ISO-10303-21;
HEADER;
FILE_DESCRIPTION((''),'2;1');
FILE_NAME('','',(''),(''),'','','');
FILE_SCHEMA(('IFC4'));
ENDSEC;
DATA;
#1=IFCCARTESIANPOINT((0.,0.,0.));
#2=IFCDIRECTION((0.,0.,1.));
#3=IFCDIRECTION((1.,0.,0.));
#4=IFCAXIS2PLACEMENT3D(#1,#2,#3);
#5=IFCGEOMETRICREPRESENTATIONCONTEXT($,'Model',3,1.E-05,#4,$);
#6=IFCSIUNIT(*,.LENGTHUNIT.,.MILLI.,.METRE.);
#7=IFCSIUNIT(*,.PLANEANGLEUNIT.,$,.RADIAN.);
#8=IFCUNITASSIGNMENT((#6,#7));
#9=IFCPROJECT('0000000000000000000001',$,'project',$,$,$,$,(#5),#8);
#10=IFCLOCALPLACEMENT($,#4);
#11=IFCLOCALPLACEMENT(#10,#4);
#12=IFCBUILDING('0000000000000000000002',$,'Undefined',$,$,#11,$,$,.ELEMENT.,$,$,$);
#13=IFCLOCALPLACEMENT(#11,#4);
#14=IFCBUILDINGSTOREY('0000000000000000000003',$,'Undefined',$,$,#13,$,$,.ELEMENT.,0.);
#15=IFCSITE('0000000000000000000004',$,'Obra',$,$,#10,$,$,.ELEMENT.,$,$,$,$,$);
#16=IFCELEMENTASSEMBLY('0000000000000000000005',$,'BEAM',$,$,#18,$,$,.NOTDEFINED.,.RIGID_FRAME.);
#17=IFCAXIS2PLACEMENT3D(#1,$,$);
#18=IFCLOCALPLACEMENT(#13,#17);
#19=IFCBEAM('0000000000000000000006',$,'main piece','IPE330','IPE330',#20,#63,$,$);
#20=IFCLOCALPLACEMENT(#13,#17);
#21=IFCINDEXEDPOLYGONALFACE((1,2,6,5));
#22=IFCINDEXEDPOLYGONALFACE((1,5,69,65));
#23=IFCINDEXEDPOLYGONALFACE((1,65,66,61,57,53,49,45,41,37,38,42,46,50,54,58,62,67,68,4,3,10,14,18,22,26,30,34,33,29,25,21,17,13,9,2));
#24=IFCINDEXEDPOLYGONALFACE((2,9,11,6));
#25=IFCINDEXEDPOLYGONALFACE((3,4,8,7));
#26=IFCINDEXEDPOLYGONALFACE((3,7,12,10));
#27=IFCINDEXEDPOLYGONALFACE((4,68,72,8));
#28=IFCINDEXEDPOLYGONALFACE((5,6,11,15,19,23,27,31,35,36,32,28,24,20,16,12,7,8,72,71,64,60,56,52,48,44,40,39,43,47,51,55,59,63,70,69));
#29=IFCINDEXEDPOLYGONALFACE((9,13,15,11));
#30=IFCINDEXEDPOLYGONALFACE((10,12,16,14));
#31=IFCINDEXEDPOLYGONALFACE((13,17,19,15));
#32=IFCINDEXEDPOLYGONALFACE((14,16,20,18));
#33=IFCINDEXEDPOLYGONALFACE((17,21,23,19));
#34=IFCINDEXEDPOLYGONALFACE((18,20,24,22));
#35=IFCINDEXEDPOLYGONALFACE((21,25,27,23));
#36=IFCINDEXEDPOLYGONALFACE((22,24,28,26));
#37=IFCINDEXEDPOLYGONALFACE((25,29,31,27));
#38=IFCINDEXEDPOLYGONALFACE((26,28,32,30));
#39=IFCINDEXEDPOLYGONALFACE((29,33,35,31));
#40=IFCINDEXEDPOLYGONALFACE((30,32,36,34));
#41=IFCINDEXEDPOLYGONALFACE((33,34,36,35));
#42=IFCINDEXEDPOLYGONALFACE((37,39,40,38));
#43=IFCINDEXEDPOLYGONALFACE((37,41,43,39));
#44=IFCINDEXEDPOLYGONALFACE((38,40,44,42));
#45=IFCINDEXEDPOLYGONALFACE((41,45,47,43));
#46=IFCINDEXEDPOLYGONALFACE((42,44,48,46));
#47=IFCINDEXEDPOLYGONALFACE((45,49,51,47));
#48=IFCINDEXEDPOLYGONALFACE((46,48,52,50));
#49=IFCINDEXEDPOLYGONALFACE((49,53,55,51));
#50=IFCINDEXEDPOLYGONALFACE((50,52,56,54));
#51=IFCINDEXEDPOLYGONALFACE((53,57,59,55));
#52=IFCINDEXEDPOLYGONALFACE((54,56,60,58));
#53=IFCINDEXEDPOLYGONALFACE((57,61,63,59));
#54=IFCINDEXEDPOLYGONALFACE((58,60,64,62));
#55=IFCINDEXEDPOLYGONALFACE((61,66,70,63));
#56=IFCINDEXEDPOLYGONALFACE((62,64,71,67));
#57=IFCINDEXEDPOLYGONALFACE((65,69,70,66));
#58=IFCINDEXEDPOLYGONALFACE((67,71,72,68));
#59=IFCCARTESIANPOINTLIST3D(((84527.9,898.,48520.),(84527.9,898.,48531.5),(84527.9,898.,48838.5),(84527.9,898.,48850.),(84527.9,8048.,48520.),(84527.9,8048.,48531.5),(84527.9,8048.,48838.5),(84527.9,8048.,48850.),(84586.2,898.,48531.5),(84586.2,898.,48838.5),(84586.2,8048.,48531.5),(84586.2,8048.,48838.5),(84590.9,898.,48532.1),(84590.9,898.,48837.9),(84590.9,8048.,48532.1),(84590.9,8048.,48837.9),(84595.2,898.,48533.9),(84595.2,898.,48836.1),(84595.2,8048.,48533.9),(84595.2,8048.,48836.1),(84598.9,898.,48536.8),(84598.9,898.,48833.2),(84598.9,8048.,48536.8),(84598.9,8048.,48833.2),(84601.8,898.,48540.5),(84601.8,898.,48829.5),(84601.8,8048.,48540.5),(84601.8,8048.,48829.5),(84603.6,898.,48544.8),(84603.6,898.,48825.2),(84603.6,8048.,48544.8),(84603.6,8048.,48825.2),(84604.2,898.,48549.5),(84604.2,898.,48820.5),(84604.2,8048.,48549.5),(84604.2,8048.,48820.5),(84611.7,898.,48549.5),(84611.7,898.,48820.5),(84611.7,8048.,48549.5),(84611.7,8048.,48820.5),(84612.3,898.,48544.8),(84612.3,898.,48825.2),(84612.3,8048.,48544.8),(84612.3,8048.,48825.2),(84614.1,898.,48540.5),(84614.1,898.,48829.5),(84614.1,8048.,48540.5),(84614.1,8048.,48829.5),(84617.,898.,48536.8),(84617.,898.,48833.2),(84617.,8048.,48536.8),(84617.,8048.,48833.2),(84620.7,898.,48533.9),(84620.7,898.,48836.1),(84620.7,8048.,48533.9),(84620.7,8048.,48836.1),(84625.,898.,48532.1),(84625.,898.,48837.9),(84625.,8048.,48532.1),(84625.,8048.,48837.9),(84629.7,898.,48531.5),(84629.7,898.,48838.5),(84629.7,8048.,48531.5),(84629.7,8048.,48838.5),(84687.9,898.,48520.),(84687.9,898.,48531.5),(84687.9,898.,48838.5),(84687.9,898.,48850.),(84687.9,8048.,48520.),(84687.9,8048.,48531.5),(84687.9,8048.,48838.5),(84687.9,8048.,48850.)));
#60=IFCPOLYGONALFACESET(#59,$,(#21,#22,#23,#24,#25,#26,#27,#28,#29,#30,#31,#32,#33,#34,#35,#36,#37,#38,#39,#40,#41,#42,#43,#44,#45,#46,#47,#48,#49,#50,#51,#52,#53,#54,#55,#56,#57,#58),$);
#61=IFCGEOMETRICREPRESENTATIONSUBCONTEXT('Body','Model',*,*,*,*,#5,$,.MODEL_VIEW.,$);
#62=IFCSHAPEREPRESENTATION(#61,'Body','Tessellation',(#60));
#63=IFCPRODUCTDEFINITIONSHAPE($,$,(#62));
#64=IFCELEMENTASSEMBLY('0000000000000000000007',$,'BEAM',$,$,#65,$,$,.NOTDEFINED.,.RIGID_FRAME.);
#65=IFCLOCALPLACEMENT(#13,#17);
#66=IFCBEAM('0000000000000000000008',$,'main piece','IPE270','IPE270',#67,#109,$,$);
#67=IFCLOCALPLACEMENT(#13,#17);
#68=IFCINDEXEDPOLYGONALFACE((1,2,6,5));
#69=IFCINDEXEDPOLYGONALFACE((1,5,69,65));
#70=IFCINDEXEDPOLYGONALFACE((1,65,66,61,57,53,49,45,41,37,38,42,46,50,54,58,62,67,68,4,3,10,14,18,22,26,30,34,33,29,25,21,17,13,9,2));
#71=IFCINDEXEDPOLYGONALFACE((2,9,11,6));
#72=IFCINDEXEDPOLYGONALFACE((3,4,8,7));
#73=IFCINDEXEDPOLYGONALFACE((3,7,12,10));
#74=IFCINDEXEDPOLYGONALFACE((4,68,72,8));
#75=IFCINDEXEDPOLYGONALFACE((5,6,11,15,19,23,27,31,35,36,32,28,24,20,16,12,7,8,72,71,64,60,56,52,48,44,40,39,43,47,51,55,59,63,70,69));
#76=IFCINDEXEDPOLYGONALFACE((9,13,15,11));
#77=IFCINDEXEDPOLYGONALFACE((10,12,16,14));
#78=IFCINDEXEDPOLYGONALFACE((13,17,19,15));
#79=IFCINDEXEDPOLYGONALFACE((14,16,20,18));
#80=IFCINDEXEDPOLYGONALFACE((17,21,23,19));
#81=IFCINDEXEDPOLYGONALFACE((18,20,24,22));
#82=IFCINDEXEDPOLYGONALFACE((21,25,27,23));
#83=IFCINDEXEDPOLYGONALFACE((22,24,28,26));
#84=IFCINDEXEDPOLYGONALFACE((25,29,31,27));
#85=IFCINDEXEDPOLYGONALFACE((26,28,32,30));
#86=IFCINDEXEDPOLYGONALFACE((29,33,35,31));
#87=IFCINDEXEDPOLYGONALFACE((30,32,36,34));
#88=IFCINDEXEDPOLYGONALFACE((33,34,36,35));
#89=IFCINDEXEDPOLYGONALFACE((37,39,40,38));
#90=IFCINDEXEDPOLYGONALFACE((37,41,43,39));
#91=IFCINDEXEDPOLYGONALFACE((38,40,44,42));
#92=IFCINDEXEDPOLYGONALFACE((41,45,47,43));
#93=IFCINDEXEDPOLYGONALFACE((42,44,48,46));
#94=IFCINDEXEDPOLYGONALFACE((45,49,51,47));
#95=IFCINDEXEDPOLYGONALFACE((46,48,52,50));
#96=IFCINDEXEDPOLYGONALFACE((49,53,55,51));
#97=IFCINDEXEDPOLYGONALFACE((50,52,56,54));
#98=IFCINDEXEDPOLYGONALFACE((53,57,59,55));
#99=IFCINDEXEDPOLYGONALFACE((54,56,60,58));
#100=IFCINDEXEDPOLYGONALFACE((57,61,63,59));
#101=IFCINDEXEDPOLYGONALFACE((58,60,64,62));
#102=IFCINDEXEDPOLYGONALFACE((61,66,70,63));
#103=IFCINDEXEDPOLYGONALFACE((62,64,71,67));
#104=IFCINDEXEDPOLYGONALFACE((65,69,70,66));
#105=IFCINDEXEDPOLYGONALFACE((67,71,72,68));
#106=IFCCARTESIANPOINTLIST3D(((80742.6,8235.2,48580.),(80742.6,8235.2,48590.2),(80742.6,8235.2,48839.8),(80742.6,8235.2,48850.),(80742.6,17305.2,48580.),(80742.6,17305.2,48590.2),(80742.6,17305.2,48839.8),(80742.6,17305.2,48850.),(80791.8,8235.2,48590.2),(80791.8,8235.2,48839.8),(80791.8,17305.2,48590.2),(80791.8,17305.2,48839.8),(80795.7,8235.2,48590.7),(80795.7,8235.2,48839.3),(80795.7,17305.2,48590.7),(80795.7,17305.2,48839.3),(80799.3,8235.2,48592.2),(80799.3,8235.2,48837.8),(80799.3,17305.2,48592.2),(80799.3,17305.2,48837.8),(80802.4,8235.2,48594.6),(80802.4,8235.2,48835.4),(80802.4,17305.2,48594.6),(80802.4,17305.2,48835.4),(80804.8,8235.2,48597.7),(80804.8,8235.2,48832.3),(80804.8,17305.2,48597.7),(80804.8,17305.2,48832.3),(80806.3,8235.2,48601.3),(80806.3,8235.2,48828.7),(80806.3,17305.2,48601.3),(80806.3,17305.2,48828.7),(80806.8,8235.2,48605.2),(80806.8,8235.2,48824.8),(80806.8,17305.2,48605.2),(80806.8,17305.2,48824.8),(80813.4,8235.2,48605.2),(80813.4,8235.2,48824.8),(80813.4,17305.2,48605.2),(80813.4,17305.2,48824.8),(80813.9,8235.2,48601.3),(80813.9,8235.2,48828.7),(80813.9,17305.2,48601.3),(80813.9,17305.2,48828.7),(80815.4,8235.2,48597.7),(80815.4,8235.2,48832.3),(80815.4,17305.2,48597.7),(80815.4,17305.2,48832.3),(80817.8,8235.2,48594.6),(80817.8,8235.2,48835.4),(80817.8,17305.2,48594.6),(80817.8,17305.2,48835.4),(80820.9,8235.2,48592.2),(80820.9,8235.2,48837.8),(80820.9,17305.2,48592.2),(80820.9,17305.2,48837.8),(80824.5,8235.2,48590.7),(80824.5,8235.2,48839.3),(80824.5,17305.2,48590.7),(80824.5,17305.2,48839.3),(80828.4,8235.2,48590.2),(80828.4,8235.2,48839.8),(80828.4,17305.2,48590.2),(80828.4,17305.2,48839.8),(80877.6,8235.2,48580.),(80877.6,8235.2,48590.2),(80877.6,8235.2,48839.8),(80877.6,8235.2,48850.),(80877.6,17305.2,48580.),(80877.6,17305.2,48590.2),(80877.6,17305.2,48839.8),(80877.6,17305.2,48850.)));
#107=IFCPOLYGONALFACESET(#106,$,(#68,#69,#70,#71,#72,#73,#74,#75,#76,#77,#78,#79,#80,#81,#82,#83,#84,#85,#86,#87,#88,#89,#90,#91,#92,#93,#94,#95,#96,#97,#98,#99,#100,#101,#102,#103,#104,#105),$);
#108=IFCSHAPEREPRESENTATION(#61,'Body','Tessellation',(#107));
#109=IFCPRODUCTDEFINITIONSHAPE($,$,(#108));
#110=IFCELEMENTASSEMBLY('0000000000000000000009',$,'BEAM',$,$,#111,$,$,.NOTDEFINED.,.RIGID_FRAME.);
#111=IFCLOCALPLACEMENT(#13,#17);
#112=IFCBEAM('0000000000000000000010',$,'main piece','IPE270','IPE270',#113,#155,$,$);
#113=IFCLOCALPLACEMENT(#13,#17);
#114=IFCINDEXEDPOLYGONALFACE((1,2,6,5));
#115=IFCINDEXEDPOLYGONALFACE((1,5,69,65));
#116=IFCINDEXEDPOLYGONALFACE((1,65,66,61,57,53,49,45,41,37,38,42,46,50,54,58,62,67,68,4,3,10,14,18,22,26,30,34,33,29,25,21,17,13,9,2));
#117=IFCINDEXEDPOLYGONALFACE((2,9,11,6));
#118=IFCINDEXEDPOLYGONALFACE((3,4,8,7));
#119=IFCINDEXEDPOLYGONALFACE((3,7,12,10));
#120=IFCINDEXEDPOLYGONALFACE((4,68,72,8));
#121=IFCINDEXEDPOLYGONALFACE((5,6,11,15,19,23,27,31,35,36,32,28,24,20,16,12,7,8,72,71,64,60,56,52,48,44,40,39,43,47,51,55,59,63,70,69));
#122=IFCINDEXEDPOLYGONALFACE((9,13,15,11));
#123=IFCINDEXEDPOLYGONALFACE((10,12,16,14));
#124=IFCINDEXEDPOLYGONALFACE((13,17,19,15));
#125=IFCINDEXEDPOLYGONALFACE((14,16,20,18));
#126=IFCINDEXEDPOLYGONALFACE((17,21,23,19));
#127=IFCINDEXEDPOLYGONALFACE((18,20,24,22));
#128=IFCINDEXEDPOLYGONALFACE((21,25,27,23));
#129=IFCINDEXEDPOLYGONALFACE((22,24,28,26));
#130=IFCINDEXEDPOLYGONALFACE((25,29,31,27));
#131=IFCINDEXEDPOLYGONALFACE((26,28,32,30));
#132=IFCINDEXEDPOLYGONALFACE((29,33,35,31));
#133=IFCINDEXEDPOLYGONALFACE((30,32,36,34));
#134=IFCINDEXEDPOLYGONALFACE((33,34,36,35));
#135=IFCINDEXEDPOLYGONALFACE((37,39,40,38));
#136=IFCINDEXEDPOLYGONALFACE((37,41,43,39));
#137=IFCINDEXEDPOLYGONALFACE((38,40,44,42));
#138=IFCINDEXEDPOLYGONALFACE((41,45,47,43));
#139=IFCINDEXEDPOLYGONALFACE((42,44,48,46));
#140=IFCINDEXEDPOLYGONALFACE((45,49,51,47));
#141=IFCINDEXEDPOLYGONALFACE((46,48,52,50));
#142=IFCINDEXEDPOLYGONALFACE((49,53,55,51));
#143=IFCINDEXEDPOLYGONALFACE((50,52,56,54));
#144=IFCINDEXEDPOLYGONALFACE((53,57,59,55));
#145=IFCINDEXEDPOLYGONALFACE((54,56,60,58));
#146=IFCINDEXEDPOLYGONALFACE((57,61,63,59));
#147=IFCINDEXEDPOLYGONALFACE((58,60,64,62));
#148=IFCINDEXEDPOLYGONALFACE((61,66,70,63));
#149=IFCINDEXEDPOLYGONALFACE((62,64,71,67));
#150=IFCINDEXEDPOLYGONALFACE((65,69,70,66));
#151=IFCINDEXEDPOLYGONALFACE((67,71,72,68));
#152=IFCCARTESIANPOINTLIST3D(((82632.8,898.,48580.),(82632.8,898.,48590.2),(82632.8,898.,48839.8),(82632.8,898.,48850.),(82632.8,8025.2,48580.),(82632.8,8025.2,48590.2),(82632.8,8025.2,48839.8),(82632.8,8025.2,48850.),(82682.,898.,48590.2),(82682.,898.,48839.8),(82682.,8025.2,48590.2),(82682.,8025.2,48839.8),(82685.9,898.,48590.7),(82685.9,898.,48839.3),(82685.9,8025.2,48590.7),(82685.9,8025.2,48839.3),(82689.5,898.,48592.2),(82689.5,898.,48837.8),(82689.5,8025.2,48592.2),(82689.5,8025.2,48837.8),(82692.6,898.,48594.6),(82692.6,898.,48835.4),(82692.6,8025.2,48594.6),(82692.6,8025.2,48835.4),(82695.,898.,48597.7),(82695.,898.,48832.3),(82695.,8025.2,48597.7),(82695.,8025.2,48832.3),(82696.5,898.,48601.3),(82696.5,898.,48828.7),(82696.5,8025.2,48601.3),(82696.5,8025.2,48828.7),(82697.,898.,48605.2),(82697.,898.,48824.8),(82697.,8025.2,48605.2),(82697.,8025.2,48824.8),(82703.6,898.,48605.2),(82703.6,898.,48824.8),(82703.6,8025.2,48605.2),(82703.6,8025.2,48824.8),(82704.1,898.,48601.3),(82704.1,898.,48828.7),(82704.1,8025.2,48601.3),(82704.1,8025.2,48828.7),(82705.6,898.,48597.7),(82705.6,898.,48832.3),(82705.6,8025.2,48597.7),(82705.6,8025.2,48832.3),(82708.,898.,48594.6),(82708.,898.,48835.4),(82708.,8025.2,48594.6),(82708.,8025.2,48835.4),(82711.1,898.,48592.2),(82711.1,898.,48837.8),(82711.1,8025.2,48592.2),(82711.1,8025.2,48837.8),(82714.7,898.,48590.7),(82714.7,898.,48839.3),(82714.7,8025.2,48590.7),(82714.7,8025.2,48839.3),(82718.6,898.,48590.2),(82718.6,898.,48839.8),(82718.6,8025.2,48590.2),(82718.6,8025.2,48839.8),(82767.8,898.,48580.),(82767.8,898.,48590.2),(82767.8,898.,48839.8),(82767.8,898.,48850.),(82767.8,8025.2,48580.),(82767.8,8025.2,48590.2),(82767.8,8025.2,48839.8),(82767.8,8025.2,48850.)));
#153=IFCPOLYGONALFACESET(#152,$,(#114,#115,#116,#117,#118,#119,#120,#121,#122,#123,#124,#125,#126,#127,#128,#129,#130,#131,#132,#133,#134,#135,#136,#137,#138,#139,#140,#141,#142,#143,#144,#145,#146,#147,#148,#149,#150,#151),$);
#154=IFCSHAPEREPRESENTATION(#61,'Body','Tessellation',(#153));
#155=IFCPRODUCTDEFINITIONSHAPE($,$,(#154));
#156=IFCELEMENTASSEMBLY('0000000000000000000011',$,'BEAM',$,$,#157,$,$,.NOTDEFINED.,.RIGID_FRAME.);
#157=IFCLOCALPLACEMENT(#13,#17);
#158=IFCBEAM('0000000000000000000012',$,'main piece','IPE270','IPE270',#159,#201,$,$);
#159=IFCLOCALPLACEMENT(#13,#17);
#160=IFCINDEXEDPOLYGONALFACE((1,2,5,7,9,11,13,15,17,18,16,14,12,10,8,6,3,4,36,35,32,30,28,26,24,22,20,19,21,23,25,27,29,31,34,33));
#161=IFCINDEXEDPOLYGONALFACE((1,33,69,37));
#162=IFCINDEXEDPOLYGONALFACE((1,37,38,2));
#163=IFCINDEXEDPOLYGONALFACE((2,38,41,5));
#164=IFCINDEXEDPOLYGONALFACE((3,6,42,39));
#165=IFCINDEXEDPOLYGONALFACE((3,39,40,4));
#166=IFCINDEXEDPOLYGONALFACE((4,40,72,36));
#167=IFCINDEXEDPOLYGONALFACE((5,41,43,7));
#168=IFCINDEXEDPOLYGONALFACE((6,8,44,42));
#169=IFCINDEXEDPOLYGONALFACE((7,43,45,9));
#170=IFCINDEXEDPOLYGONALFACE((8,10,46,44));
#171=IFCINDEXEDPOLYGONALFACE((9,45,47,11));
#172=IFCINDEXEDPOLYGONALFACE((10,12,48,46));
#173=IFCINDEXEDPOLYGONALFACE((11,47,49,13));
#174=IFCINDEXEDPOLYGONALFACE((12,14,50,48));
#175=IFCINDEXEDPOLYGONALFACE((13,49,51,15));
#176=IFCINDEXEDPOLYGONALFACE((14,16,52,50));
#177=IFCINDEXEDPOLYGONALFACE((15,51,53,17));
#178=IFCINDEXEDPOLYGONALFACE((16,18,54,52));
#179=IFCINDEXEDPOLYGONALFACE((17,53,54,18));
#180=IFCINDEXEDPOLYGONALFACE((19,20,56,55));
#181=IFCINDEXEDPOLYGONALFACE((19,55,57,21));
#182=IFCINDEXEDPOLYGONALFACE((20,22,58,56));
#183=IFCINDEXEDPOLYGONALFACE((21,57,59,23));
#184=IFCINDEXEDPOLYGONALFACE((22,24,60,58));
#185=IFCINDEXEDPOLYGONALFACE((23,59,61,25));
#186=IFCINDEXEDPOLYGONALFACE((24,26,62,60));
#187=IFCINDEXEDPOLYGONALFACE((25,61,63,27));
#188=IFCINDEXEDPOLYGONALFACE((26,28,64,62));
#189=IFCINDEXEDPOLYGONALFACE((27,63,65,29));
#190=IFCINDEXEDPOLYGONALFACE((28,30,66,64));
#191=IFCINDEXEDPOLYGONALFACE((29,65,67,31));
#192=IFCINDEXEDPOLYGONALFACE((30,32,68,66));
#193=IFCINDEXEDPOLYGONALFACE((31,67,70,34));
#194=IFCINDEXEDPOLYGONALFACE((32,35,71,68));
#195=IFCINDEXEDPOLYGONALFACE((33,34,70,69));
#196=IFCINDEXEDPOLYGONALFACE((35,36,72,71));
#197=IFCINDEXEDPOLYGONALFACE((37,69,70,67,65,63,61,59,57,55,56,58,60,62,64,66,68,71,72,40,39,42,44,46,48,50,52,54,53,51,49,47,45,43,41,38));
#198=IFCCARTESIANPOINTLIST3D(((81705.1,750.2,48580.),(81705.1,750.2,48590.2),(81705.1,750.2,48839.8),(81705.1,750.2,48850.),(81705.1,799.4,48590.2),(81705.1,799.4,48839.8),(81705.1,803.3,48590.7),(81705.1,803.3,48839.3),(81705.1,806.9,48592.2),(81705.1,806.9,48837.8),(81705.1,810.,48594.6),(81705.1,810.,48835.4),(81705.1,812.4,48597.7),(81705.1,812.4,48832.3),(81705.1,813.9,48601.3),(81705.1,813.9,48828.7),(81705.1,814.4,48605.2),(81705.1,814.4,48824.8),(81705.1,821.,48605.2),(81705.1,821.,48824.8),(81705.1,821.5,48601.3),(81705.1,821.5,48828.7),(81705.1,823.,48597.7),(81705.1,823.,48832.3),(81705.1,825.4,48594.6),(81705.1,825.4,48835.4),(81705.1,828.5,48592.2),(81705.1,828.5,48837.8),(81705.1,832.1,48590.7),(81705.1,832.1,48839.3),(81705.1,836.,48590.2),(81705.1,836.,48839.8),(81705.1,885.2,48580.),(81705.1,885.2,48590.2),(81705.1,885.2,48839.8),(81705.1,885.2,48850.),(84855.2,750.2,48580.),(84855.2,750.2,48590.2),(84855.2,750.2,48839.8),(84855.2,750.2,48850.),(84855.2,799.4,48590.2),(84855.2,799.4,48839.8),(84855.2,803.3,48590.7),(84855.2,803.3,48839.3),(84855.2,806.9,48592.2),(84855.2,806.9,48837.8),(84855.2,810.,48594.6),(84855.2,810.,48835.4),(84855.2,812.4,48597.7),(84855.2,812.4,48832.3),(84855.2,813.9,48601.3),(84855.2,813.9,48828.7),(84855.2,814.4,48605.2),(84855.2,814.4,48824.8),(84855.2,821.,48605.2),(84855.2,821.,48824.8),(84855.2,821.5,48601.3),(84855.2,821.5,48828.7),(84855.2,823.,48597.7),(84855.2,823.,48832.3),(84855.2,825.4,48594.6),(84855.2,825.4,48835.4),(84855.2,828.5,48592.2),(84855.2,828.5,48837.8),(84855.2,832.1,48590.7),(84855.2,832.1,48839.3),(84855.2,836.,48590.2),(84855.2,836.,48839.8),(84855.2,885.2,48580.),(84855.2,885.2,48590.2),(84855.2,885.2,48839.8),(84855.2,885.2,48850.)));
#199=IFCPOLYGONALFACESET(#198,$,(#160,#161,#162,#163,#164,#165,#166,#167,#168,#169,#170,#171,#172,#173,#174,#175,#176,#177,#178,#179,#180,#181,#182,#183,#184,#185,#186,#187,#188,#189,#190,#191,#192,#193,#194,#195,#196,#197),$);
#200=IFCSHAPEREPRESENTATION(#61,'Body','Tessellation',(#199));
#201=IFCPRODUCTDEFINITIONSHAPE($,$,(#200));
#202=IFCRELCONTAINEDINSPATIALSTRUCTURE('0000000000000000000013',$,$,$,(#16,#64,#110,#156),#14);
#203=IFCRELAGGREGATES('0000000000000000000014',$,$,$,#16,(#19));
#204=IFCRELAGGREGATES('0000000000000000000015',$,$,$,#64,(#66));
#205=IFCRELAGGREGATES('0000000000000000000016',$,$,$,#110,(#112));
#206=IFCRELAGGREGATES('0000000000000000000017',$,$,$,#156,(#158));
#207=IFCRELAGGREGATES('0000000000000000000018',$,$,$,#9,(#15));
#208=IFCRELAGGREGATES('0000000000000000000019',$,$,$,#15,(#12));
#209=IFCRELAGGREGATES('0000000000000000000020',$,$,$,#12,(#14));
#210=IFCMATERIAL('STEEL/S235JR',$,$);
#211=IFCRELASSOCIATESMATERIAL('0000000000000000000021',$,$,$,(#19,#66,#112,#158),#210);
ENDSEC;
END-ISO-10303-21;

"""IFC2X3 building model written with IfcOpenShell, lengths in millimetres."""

from ifc_helpers import new_model, si_unit, frame, origin_with_axes, origin_2d_with_axis, place, context, subcontext, project, spatial, i_section, extrude, material, element, aggregate, save


model = new_model("IFC2X3")

# Units and contexts
model_context = context("Model", 3, precision=1e-05, world=origin_with_axes())
body_context = subcontext(model_context, "Body", "Model", "MODEL_VIEW")
ifc_project = project(units=[si_unit("LENGTHUNIT", "METRE", prefix="MILLI"), si_unit("PLANEANGLEUNIT", "RADIAN")], contexts=[model_context])

# Site, building, storey
site_placement = place(None, origin_with_axes())
site = spatial("IfcSite", under=ifc_project, at=site_placement, Name="Obra", CompositionType="ELEMENT")
building_placement = place(site_placement, origin_with_axes())
building = spatial("IfcBuilding", under=site, at=building_placement, Name="Undefined", CompositionType="ELEMENT")
storey_placement = place(building_placement, origin_with_axes())
storey = spatial("IfcBuildingStorey", under=building, at=storey_placement, Name="Undefined", CompositionType="ELEMENT", Elevation=0.0)

# Shared definitions
ifc_material_1 = material(Name="STEEL/S235JR")

# Element assemblies, beams
assembly_1_placement = place(storey_placement, origin_with_axes())
assembly_1 = element("IfcElementAssembly", 1, at=assembly_1_placement, inside=storey, Name="BEAM", AssemblyPlace="NOTDEFINED", PredefinedType="RIGID_FRAME")
beam_1_placement = place(assembly_1_placement, frame((84607.9, 898.0, 48685.0), z_axis=(0.0, 0.0, 1.0), x_axis=(0.0, 1.0, 0.0)))
beam_1 = element("IfcBeam", 2, at=beam_1_placement, material=ifc_material_1, Name="main piece", Description="IPE330", ObjectType="IPE330", context=body_context, shape_type="SweptSolid", body=[
    extrude(i_section(OverallWidth=160.0, OverallDepth=330.0, WebThickness=7.5, FlangeThickness=11.5, FilletRadius=18.0, at=origin_2d_with_axis()), frame((7150.0, 0.0, 0.0), z_axis=(-1.0, 0.0, 0.0), x_axis=(0.0, -1.0, 0.0)), (0.0, 0.0, 1.0), 7150.0),
])
aggregate(assembly_1, [beam_1])
assembly_2_placement = place(storey_placement, origin_with_axes())
assembly_2 = element("IfcElementAssembly", 3, at=assembly_2_placement, inside=storey, Name="BEAM", AssemblyPlace="NOTDEFINED", PredefinedType="RIGID_FRAME")
beam_2_placement = place(assembly_2_placement, frame((80810.1, 8235.2, 48715.0), z_axis=(0.0, 0.0, 1.0), x_axis=(0.0, 1.0, 0.0)))
beam_2 = element("IfcBeam", 4, at=beam_2_placement, material=ifc_material_1, Name="main piece", Description="IPE270", ObjectType="IPE270", context=body_context, shape_type="SweptSolid", body=[
    extrude(i_section(OverallWidth=135.0, OverallDepth=270.0, WebThickness=6.6, FlangeThickness=10.2, FilletRadius=15.0, at=origin_2d_with_axis()), frame((9070.0, 0.0, 0.0), z_axis=(-1.0, 0.0, 0.0), x_axis=(0.0, -1.0, 0.0)), (0.0, 0.0, 1.0), 9070.0),
])
aggregate(assembly_2, [beam_2])
assembly_3_placement = place(storey_placement, origin_with_axes())
assembly_3 = element("IfcElementAssembly", 5, at=assembly_3_placement, inside=storey, Name="BEAM", AssemblyPlace="NOTDEFINED", PredefinedType="RIGID_FRAME")
beam_3_placement = place(assembly_3_placement, frame((82700.3, 898.0, 48715.0), z_axis=(0.0, 0.0, 1.0), x_axis=(0.0, 1.0, 0.0)))
beam_3 = element("IfcBeam", 6, at=beam_3_placement, material=ifc_material_1, Name="main piece", Description="IPE270", ObjectType="IPE270", context=body_context, shape_type="SweptSolid", body=[
    extrude(i_section(OverallWidth=135.0, OverallDepth=270.0, WebThickness=6.6, FlangeThickness=10.2, FilletRadius=15.0, at=origin_2d_with_axis()), frame((7127.2, 0.0, 0.0), z_axis=(-1.0, 0.0, 0.0), x_axis=(0.0, -1.0, 0.0)), (0.0, 0.0, 1.0), 7127.2),
])
aggregate(assembly_3, [beam_3])
assembly_4_placement = place(storey_placement, origin_with_axes())
assembly_4 = element("IfcElementAssembly", 7, at=assembly_4_placement, inside=storey, Name="BEAM", AssemblyPlace="NOTDEFINED", PredefinedType="RIGID_FRAME")
beam_4_placement = place(assembly_4_placement, frame((81705.1, 817.7, 48715.0), z_axis=(0.0, 0.0, 1.0), x_axis=(1.0, 0.0, 0.0)))
beam_4 = element("IfcBeam", 8, at=beam_4_placement, material=ifc_material_1, Name="main piece", Description="IPE270", ObjectType="IPE270", context=body_context, shape_type="SweptSolid", body=[
    extrude(i_section(OverallWidth=135.0, OverallDepth=270.0, WebThickness=6.6, FlangeThickness=10.2, FilletRadius=15.0, at=origin_2d_with_axis()), frame((3150.0, 0.0, 0.0), z_axis=(-1.0, 0.0, 0.0), x_axis=(0.0, -1.0, 0.0)), (0.0, 0.0, 1.0), 3150.0),
])
aggregate(assembly_4, [beam_4])

save(model, "model.ifc")
